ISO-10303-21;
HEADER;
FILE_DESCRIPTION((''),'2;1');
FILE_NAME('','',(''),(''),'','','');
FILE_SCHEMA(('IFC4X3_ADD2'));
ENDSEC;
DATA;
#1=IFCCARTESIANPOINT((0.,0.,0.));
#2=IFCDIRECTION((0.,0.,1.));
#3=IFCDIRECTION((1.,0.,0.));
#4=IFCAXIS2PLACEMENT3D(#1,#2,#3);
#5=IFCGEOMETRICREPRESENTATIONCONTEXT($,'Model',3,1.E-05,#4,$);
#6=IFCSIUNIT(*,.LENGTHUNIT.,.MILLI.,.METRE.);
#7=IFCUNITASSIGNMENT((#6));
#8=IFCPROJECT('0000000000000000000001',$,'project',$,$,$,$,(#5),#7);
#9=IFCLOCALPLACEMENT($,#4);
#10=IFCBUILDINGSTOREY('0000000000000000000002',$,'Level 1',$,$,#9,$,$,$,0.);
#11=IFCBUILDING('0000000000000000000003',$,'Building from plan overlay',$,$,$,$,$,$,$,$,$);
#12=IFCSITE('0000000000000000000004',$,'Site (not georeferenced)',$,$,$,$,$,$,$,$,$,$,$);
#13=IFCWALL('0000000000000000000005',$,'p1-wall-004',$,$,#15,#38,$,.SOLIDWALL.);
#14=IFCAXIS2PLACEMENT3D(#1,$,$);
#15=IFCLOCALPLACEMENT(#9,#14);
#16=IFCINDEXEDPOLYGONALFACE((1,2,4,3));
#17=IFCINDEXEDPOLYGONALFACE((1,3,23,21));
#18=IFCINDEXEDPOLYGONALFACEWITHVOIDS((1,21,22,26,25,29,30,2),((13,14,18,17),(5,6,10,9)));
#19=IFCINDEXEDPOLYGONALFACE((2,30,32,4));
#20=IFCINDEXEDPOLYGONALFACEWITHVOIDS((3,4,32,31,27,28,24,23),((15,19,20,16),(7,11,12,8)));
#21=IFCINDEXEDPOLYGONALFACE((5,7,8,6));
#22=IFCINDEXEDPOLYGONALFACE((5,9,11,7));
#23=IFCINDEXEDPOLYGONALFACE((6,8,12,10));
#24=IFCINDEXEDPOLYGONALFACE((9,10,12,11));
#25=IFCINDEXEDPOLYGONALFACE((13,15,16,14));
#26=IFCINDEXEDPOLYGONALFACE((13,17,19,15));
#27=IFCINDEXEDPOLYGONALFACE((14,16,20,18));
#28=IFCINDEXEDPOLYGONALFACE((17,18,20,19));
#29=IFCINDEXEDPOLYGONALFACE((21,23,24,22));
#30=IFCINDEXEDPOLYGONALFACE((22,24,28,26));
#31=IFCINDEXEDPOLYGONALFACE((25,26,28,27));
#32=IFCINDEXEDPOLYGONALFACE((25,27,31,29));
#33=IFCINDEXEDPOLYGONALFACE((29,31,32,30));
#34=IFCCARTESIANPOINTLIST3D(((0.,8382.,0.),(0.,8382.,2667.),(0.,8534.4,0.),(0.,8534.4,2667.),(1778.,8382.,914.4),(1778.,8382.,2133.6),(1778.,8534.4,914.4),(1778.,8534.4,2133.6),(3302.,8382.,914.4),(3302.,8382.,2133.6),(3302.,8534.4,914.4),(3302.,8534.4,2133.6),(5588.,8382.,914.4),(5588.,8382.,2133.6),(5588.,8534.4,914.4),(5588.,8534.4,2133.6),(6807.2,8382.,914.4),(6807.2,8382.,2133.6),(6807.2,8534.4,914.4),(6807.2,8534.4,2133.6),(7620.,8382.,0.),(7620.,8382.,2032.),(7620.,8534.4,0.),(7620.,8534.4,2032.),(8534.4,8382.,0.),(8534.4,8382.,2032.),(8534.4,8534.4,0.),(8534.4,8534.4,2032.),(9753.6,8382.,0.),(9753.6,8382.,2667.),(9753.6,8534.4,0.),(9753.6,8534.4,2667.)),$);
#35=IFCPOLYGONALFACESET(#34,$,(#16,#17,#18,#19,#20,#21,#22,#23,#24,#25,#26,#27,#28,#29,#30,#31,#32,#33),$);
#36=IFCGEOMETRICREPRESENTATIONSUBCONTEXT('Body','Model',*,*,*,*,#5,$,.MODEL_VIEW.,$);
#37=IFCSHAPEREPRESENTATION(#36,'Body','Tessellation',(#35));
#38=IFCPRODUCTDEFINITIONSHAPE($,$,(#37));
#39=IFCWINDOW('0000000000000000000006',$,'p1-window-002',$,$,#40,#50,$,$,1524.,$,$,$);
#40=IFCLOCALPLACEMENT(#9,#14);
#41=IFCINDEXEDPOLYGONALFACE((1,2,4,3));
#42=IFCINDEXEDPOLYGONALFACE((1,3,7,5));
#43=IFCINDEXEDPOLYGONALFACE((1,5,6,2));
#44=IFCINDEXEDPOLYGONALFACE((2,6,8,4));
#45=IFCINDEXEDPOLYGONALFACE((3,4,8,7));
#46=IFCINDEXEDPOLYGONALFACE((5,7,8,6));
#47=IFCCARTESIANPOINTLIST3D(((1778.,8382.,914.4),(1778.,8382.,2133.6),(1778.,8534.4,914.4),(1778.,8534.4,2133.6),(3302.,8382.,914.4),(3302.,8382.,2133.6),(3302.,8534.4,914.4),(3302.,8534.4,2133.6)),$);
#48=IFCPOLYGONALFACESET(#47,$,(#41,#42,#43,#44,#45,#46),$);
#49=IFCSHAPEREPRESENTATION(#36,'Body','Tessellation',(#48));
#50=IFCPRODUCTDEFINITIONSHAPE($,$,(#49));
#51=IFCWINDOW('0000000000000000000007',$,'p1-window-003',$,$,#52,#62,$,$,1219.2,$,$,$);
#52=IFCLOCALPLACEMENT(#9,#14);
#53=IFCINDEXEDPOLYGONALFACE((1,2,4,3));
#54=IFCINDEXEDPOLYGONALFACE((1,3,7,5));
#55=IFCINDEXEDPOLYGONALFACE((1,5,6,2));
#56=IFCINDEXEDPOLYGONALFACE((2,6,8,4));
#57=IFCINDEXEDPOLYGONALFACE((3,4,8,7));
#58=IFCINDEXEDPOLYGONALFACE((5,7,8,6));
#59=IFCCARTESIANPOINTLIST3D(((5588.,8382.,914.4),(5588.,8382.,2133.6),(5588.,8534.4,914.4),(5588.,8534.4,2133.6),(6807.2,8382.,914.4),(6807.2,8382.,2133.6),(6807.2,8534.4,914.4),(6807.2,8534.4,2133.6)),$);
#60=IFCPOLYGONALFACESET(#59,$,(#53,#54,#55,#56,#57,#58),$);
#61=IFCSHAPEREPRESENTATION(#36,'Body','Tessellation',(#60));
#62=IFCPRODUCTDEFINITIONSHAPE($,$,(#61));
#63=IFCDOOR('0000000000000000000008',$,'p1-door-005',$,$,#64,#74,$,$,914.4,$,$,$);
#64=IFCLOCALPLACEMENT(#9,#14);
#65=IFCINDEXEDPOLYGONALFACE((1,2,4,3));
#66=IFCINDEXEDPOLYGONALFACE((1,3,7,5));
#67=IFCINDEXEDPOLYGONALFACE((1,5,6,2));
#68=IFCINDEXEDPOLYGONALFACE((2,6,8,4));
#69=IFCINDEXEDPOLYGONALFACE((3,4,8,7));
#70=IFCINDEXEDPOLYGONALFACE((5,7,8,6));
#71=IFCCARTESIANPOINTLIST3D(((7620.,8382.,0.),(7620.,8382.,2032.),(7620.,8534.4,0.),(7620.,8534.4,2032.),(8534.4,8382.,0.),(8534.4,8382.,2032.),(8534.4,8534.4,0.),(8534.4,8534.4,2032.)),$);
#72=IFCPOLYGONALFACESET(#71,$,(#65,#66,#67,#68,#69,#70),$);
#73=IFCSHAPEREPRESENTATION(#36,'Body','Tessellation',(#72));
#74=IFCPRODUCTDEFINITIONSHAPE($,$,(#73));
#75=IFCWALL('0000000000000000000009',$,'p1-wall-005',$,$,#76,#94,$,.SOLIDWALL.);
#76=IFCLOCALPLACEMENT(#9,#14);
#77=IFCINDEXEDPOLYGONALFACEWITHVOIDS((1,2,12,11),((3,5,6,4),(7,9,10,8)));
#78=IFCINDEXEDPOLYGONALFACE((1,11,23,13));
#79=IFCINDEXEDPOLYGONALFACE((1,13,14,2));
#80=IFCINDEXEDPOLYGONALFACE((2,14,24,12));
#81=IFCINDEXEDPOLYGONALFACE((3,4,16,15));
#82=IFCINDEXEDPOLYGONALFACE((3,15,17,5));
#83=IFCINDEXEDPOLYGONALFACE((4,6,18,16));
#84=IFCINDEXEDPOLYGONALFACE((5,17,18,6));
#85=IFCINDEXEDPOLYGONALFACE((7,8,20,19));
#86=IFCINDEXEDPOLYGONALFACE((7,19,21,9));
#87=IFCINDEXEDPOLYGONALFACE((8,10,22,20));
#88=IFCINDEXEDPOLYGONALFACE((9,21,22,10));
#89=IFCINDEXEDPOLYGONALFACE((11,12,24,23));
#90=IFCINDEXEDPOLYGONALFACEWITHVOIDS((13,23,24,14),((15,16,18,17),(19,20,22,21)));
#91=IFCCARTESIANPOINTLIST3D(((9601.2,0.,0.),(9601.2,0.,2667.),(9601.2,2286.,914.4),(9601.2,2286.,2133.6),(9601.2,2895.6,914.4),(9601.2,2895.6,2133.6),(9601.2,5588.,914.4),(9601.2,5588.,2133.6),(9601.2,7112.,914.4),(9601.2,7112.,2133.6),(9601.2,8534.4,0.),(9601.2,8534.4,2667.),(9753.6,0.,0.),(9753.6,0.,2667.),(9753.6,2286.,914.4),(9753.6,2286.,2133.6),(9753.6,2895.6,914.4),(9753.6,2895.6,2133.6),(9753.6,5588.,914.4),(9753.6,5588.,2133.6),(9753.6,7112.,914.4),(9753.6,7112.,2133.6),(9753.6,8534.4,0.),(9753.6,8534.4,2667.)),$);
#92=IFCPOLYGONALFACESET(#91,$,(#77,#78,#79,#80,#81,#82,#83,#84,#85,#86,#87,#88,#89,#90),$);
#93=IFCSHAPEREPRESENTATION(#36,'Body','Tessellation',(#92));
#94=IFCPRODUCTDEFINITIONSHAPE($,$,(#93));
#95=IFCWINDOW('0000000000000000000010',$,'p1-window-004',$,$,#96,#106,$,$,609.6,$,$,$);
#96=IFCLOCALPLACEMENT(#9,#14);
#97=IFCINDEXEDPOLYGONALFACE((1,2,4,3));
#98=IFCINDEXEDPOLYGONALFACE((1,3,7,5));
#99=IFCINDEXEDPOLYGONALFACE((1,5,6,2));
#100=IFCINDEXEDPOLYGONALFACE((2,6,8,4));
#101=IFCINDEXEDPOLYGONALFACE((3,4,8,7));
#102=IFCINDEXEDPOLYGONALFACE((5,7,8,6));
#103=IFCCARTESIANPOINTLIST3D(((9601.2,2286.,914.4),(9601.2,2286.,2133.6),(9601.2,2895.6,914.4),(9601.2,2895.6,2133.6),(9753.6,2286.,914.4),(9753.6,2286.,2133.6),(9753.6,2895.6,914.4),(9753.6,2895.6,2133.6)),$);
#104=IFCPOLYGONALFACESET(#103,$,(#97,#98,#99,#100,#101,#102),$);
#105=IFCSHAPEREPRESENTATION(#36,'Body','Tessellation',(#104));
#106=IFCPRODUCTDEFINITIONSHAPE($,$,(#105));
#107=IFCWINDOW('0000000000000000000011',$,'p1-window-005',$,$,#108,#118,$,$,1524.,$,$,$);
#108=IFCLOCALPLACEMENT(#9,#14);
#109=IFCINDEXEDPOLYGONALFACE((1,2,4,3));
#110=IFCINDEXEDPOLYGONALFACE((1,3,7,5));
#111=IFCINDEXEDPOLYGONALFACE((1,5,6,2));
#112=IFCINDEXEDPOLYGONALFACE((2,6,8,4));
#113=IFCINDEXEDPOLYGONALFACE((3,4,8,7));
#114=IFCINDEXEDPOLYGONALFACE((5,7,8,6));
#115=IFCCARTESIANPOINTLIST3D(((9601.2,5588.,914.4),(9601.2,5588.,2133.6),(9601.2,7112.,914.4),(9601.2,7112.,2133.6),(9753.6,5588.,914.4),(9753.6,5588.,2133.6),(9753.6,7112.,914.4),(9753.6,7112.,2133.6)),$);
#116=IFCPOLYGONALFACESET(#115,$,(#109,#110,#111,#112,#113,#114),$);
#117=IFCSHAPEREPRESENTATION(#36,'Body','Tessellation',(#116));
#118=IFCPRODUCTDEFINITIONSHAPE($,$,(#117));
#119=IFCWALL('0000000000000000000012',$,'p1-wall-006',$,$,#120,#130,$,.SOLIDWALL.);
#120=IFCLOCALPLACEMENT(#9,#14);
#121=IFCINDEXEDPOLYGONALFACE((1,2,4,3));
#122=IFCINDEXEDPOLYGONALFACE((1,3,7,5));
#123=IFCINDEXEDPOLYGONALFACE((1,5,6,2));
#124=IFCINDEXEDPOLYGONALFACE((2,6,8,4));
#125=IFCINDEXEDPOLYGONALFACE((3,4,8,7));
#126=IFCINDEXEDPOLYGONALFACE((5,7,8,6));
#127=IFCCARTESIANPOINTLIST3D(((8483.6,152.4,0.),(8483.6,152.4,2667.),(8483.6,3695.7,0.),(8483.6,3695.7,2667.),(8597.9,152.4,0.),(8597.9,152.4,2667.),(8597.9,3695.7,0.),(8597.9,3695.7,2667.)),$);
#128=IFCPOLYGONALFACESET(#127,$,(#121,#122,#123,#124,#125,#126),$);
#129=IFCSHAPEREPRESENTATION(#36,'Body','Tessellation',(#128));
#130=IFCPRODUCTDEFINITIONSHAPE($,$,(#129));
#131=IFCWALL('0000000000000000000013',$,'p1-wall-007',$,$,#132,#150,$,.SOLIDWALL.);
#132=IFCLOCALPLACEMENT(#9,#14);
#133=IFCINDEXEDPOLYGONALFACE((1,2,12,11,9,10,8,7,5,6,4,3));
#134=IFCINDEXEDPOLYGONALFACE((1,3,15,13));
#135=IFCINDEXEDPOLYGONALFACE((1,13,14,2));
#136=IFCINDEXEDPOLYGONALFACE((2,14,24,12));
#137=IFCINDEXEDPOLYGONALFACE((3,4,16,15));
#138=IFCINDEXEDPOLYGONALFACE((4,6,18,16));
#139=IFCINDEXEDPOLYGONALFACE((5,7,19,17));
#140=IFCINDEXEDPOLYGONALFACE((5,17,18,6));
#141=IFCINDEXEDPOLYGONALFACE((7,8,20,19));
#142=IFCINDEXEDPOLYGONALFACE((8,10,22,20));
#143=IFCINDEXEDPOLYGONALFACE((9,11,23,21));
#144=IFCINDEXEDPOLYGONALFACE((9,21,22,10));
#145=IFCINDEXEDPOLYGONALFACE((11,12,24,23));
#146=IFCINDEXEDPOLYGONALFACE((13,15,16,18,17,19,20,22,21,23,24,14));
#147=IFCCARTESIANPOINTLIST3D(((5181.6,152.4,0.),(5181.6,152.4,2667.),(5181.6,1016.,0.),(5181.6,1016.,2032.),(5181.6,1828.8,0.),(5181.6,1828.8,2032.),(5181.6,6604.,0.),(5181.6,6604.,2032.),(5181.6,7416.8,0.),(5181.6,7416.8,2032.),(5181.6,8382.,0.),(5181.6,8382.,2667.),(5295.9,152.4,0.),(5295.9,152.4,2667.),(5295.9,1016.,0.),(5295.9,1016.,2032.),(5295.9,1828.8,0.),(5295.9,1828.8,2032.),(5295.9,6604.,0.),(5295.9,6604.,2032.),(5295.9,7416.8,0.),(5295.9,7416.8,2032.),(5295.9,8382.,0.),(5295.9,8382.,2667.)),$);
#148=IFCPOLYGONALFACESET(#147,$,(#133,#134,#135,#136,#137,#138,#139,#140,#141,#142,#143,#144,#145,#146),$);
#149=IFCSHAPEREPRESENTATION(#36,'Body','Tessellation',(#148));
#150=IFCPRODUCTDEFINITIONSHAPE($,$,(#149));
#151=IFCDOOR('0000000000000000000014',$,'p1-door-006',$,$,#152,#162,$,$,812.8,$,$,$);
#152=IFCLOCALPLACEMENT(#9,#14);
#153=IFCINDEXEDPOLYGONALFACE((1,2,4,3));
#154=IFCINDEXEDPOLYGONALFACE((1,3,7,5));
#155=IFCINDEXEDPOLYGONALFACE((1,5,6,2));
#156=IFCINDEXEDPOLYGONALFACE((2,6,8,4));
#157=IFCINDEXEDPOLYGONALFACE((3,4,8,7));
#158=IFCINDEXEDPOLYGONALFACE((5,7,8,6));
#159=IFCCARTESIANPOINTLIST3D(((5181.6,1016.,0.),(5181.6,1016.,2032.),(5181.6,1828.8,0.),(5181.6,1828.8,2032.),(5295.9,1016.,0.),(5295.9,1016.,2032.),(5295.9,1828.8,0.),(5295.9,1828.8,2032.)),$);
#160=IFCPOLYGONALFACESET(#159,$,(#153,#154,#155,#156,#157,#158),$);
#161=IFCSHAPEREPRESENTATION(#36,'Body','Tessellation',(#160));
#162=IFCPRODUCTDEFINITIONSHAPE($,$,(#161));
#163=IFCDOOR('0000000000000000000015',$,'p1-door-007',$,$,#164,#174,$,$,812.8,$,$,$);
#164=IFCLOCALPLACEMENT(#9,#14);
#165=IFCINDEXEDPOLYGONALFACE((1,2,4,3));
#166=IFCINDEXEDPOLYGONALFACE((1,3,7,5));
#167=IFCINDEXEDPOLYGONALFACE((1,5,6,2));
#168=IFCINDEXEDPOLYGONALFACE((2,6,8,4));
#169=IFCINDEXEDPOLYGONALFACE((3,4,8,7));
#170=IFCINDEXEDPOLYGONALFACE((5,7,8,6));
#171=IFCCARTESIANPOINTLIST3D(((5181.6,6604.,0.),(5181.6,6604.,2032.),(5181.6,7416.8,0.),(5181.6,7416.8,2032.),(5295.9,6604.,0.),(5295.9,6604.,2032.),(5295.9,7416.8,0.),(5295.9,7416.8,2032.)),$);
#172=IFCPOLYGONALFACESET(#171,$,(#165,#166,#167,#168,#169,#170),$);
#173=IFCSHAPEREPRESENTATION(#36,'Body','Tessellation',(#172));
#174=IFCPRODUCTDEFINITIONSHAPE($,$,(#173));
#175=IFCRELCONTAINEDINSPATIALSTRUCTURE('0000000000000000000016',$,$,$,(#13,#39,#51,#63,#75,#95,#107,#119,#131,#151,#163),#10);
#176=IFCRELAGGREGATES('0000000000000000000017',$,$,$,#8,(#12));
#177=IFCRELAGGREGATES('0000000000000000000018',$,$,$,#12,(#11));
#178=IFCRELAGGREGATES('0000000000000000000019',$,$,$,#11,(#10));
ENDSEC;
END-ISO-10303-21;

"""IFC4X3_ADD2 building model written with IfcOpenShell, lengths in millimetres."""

from ifc_helpers import new_model, si_unit, frame, origin, origin_with_axes, place, context, subcontext, project, spatial, polyline, outline, extrude, element, fill, save


model = new_model("IFC4X3_ADD2")

# Units and contexts
model_context = context("Model", 3, precision=1e-05, world=origin_with_axes())
body_context = subcontext(model_context, "Body", "Model", "MODEL_VIEW")
ifc_project = project(units=[si_unit("LENGTHUNIT", "METRE", prefix="MILLI")], contexts=[model_context])

# Site, building, storey
site = spatial("IfcSite", under=ifc_project, Name="Site (not georeferenced)")
building = spatial("IfcBuilding", under=site, Name="Building from plan overlay")
storey_placement = place(None, origin_with_axes())
storey = spatial("IfcBuildingStorey", under=building, at=storey_placement, Name="Level 1", Elevation=0.0)

# Wall, openings, windows, door
wall_1_placement = place(storey_placement, origin_with_axes())
wall_1 = element("IfcWall", 1, at=wall_1_placement, inside=storey, Name="p1-wall-004", PredefinedType="SOLIDWALL", context=body_context, shape_type="SweptSolid", body=[
    extrude(outline(polyline([(0.0, 8382.0), (9753.6, 8382.0), (9753.6, 8534.4), (0.0, 8534.4), (0.0, 8382.0)])), origin(), (0.0, 0.0, 1.0), 2667.0),
])
opening_1_placement = place(wall_1_placement, origin_with_axes())
opening_1 = element("IfcOpeningElement", 2, at=opening_1_placement, cuts=wall_1, context=body_context, shape_type="SweptSolid", body=[
    extrude(outline(polyline([(1778.0, 8382.0), (3302.0, 8382.0), (3302.0, 8534.4), (1778.0, 8534.4), (1778.0, 8382.0)])), frame((0.0, 0.0, 914.4)), (0.0, 0.0, 1.0), 1219.2),
])
opening_2_placement = place(wall_1_placement, origin_with_axes())
opening_2 = element("IfcOpeningElement", 3, at=opening_2_placement, cuts=wall_1, context=body_context, shape_type="SweptSolid", body=[
    extrude(outline(polyline([(5588.0, 8382.0), (6807.2, 8382.0), (6807.2, 8534.4), (5588.0, 8534.4), (5588.0, 8382.0)])), frame((0.0, 0.0, 914.4)), (0.0, 0.0, 1.0), 1219.2),
])
opening_3_placement = place(wall_1_placement, origin_with_axes())
opening_3 = element("IfcOpeningElement", 4, at=opening_3_placement, cuts=wall_1, context=body_context, shape_type="SweptSolid", body=[
    extrude(outline(polyline([(7620.0, 8382.0), (8534.4, 8382.0), (8534.4, 8534.4), (7620.0, 8534.4), (7620.0, 8382.0)])), origin(), (0.0, 0.0, 1.0), 2032.0),
])
window_1_placement = place(storey_placement, origin_with_axes())
window_1 = element("IfcWindow", 5, at=window_1_placement, inside=storey, Name="p1-window-002", OverallWidth=1524.0, context=body_context, shape_type="SweptSolid", body=[
    extrude(outline(polyline([(1778.0, 8382.0), (3302.0, 8382.0), (3302.0, 8534.4), (1778.0, 8534.4), (1778.0, 8382.0)])), frame((0.0, 0.0, 914.4)), (0.0, 0.0, 1.0), 1219.2),
])
fill(opening_1, window_1)
window_2_placement = place(storey_placement, origin_with_axes())
window_2 = element("IfcWindow", 6, at=window_2_placement, inside=storey, Name="p1-window-003", OverallWidth=1219.2, context=body_context, shape_type="SweptSolid", body=[
    extrude(outline(polyline([(5588.0, 8382.0), (6807.2, 8382.0), (6807.2, 8534.4), (5588.0, 8534.4), (5588.0, 8382.0)])), frame((0.0, 0.0, 914.4)), (0.0, 0.0, 1.0), 1219.2),
])
fill(opening_2, window_2)
door_1_placement = place(storey_placement, origin_with_axes())
door_1 = element("IfcDoor", 7, at=door_1_placement, inside=storey, Name="p1-door-005", OverallWidth=914.4, context=body_context, shape_type="SweptSolid", body=[
    extrude(outline(polyline([(7620.0, 8382.0), (8534.4, 8382.0), (8534.4, 8534.4), (7620.0, 8534.4), (7620.0, 8382.0)])), origin(), (0.0, 0.0, 1.0), 2032.0),
])
fill(opening_3, door_1)

# Wall, openings, windows
wall_2_placement = place(storey_placement, origin_with_axes())
wall_2 = element("IfcWall", 8, at=wall_2_placement, inside=storey, Name="p1-wall-005", PredefinedType="SOLIDWALL", context=body_context, shape_type="SweptSolid", body=[
    extrude(outline(polyline([(9753.6, 0.0), (9753.6, 8534.4), (9601.2, 8534.4), (9601.2, 0.0), (9753.6, 0.0)])), origin(), (0.0, 0.0, 1.0), 2667.0),
])
opening_4_placement = place(wall_2_placement, origin_with_axes())
opening_4 = element("IfcOpeningElement", 9, at=opening_4_placement, cuts=wall_2, context=body_context, shape_type="SweptSolid", body=[
    extrude(outline(polyline([(9753.6, 2286.0), (9753.6, 2895.6), (9601.2, 2895.6), (9601.2, 2286.0), (9753.6, 2286.0)])), frame((0.0, 0.0, 914.4)), (0.0, 0.0, 1.0), 1219.2),
])
opening_5_placement = place(wall_2_placement, origin_with_axes())
opening_5 = element("IfcOpeningElement", 10, at=opening_5_placement, cuts=wall_2, context=body_context, shape_type="SweptSolid", body=[
    extrude(outline(polyline([(9753.6, 5588.0), (9753.6, 7112.0), (9601.2, 7112.0), (9601.2, 5588.0), (9753.6, 5588.0)])), frame((0.0, 0.0, 914.4)), (0.0, 0.0, 1.0), 1219.2),
])
window_3_placement = place(storey_placement, origin_with_axes())
window_3 = element("IfcWindow", 11, at=window_3_placement, inside=storey, Name="p1-window-004", OverallWidth=609.6, context=body_context, shape_type="SweptSolid", body=[
    extrude(outline(polyline([(9753.6, 2286.0), (9753.6, 2895.6), (9601.2, 2895.6), (9601.2, 2286.0), (9753.6, 2286.0)])), frame((0.0, 0.0, 914.4)), (0.0, 0.0, 1.0), 1219.2),
])
fill(opening_4, window_3)
window_4_placement = place(storey_placement, origin_with_axes())
window_4 = element("IfcWindow", 12, at=window_4_placement, inside=storey, Name="p1-window-005", OverallWidth=1524.0, context=body_context, shape_type="SweptSolid", body=[
    extrude(outline(polyline([(9753.6, 5588.0), (9753.6, 7112.0), (9601.2, 7112.0), (9601.2, 5588.0), (9753.6, 5588.0)])), frame((0.0, 0.0, 914.4)), (0.0, 0.0, 1.0), 1219.2),
])
fill(opening_5, window_4)

# Wall
wall_3_placement = place(storey_placement, origin_with_axes())
element("IfcWall", 13, at=wall_3_placement, inside=storey, Name="p1-wall-006", PredefinedType="SOLIDWALL", context=body_context, shape_type="SweptSolid", body=[
    extrude(outline(polyline([(8597.9, 152.4), (8597.9, 3695.7), (8483.6, 3695.7), (8483.6, 152.4), (8597.9, 152.4)])), origin(), (0.0, 0.0, 1.0), 2667.0),
])

# Wall, openings, doors
wall_4_placement = place(storey_placement, origin_with_axes())
wall_4 = element("IfcWall", 14, at=wall_4_placement, inside=storey, Name="p1-wall-007", PredefinedType="SOLIDWALL", context=body_context, shape_type="SweptSolid", body=[
    extrude(outline(polyline([(5295.9, 152.4), (5295.9, 8382.0), (5181.6, 8382.0), (5181.6, 152.4), (5295.9, 152.4)])), origin(), (0.0, 0.0, 1.0), 2667.0),
])
opening_6_placement = place(wall_4_placement, origin_with_axes())
opening_6 = element("IfcOpeningElement", 15, at=opening_6_placement, cuts=wall_4, context=body_context, shape_type="SweptSolid", body=[
    extrude(outline(polyline([(5295.9, 1016.0), (5295.9, 1828.8), (5181.6, 1828.8), (5181.6, 1016.0), (5295.9, 1016.0)])), origin(), (0.0, 0.0, 1.0), 2032.0),
])
opening_7_placement = place(wall_4_placement, origin_with_axes())
opening_7 = element("IfcOpeningElement", 16, at=opening_7_placement, cuts=wall_4, context=body_context, shape_type="SweptSolid", body=[
    extrude(outline(polyline([(5295.9, 6604.0), (5295.9, 7416.8), (5181.6, 7416.8), (5181.6, 6604.0), (5295.9, 6604.0)])), origin(), (0.0, 0.0, 1.0), 2032.0),
])
door_2_placement = place(storey_placement, origin_with_axes())
door_2 = element("IfcDoor", 17, at=door_2_placement, inside=storey, Name="p1-door-006", OverallWidth=812.8, context=body_context, shape_type="SweptSolid", body=[
    extrude(outline(polyline([(5295.9, 1016.0), (5295.9, 1828.8), (5181.6, 1828.8), (5181.6, 1016.0), (5295.9, 1016.0)])), origin(), (0.0, 0.0, 1.0), 2032.0),
])
fill(opening_6, door_2)
door_3_placement = place(storey_placement, origin_with_axes())
door_3 = element("IfcDoor", 18, at=door_3_placement, inside=storey, Name="p1-door-007", OverallWidth=812.8, context=body_context, shape_type="SweptSolid", body=[
    extrude(outline(polyline([(5295.9, 6604.0), (5295.9, 7416.8), (5181.6, 7416.8), (5181.6, 6604.0), (5295.9, 6604.0)])), origin(), (0.0, 0.0, 1.0), 2032.0),
])
fill(opening_7, door_3)

save(model, "model.ifc")
